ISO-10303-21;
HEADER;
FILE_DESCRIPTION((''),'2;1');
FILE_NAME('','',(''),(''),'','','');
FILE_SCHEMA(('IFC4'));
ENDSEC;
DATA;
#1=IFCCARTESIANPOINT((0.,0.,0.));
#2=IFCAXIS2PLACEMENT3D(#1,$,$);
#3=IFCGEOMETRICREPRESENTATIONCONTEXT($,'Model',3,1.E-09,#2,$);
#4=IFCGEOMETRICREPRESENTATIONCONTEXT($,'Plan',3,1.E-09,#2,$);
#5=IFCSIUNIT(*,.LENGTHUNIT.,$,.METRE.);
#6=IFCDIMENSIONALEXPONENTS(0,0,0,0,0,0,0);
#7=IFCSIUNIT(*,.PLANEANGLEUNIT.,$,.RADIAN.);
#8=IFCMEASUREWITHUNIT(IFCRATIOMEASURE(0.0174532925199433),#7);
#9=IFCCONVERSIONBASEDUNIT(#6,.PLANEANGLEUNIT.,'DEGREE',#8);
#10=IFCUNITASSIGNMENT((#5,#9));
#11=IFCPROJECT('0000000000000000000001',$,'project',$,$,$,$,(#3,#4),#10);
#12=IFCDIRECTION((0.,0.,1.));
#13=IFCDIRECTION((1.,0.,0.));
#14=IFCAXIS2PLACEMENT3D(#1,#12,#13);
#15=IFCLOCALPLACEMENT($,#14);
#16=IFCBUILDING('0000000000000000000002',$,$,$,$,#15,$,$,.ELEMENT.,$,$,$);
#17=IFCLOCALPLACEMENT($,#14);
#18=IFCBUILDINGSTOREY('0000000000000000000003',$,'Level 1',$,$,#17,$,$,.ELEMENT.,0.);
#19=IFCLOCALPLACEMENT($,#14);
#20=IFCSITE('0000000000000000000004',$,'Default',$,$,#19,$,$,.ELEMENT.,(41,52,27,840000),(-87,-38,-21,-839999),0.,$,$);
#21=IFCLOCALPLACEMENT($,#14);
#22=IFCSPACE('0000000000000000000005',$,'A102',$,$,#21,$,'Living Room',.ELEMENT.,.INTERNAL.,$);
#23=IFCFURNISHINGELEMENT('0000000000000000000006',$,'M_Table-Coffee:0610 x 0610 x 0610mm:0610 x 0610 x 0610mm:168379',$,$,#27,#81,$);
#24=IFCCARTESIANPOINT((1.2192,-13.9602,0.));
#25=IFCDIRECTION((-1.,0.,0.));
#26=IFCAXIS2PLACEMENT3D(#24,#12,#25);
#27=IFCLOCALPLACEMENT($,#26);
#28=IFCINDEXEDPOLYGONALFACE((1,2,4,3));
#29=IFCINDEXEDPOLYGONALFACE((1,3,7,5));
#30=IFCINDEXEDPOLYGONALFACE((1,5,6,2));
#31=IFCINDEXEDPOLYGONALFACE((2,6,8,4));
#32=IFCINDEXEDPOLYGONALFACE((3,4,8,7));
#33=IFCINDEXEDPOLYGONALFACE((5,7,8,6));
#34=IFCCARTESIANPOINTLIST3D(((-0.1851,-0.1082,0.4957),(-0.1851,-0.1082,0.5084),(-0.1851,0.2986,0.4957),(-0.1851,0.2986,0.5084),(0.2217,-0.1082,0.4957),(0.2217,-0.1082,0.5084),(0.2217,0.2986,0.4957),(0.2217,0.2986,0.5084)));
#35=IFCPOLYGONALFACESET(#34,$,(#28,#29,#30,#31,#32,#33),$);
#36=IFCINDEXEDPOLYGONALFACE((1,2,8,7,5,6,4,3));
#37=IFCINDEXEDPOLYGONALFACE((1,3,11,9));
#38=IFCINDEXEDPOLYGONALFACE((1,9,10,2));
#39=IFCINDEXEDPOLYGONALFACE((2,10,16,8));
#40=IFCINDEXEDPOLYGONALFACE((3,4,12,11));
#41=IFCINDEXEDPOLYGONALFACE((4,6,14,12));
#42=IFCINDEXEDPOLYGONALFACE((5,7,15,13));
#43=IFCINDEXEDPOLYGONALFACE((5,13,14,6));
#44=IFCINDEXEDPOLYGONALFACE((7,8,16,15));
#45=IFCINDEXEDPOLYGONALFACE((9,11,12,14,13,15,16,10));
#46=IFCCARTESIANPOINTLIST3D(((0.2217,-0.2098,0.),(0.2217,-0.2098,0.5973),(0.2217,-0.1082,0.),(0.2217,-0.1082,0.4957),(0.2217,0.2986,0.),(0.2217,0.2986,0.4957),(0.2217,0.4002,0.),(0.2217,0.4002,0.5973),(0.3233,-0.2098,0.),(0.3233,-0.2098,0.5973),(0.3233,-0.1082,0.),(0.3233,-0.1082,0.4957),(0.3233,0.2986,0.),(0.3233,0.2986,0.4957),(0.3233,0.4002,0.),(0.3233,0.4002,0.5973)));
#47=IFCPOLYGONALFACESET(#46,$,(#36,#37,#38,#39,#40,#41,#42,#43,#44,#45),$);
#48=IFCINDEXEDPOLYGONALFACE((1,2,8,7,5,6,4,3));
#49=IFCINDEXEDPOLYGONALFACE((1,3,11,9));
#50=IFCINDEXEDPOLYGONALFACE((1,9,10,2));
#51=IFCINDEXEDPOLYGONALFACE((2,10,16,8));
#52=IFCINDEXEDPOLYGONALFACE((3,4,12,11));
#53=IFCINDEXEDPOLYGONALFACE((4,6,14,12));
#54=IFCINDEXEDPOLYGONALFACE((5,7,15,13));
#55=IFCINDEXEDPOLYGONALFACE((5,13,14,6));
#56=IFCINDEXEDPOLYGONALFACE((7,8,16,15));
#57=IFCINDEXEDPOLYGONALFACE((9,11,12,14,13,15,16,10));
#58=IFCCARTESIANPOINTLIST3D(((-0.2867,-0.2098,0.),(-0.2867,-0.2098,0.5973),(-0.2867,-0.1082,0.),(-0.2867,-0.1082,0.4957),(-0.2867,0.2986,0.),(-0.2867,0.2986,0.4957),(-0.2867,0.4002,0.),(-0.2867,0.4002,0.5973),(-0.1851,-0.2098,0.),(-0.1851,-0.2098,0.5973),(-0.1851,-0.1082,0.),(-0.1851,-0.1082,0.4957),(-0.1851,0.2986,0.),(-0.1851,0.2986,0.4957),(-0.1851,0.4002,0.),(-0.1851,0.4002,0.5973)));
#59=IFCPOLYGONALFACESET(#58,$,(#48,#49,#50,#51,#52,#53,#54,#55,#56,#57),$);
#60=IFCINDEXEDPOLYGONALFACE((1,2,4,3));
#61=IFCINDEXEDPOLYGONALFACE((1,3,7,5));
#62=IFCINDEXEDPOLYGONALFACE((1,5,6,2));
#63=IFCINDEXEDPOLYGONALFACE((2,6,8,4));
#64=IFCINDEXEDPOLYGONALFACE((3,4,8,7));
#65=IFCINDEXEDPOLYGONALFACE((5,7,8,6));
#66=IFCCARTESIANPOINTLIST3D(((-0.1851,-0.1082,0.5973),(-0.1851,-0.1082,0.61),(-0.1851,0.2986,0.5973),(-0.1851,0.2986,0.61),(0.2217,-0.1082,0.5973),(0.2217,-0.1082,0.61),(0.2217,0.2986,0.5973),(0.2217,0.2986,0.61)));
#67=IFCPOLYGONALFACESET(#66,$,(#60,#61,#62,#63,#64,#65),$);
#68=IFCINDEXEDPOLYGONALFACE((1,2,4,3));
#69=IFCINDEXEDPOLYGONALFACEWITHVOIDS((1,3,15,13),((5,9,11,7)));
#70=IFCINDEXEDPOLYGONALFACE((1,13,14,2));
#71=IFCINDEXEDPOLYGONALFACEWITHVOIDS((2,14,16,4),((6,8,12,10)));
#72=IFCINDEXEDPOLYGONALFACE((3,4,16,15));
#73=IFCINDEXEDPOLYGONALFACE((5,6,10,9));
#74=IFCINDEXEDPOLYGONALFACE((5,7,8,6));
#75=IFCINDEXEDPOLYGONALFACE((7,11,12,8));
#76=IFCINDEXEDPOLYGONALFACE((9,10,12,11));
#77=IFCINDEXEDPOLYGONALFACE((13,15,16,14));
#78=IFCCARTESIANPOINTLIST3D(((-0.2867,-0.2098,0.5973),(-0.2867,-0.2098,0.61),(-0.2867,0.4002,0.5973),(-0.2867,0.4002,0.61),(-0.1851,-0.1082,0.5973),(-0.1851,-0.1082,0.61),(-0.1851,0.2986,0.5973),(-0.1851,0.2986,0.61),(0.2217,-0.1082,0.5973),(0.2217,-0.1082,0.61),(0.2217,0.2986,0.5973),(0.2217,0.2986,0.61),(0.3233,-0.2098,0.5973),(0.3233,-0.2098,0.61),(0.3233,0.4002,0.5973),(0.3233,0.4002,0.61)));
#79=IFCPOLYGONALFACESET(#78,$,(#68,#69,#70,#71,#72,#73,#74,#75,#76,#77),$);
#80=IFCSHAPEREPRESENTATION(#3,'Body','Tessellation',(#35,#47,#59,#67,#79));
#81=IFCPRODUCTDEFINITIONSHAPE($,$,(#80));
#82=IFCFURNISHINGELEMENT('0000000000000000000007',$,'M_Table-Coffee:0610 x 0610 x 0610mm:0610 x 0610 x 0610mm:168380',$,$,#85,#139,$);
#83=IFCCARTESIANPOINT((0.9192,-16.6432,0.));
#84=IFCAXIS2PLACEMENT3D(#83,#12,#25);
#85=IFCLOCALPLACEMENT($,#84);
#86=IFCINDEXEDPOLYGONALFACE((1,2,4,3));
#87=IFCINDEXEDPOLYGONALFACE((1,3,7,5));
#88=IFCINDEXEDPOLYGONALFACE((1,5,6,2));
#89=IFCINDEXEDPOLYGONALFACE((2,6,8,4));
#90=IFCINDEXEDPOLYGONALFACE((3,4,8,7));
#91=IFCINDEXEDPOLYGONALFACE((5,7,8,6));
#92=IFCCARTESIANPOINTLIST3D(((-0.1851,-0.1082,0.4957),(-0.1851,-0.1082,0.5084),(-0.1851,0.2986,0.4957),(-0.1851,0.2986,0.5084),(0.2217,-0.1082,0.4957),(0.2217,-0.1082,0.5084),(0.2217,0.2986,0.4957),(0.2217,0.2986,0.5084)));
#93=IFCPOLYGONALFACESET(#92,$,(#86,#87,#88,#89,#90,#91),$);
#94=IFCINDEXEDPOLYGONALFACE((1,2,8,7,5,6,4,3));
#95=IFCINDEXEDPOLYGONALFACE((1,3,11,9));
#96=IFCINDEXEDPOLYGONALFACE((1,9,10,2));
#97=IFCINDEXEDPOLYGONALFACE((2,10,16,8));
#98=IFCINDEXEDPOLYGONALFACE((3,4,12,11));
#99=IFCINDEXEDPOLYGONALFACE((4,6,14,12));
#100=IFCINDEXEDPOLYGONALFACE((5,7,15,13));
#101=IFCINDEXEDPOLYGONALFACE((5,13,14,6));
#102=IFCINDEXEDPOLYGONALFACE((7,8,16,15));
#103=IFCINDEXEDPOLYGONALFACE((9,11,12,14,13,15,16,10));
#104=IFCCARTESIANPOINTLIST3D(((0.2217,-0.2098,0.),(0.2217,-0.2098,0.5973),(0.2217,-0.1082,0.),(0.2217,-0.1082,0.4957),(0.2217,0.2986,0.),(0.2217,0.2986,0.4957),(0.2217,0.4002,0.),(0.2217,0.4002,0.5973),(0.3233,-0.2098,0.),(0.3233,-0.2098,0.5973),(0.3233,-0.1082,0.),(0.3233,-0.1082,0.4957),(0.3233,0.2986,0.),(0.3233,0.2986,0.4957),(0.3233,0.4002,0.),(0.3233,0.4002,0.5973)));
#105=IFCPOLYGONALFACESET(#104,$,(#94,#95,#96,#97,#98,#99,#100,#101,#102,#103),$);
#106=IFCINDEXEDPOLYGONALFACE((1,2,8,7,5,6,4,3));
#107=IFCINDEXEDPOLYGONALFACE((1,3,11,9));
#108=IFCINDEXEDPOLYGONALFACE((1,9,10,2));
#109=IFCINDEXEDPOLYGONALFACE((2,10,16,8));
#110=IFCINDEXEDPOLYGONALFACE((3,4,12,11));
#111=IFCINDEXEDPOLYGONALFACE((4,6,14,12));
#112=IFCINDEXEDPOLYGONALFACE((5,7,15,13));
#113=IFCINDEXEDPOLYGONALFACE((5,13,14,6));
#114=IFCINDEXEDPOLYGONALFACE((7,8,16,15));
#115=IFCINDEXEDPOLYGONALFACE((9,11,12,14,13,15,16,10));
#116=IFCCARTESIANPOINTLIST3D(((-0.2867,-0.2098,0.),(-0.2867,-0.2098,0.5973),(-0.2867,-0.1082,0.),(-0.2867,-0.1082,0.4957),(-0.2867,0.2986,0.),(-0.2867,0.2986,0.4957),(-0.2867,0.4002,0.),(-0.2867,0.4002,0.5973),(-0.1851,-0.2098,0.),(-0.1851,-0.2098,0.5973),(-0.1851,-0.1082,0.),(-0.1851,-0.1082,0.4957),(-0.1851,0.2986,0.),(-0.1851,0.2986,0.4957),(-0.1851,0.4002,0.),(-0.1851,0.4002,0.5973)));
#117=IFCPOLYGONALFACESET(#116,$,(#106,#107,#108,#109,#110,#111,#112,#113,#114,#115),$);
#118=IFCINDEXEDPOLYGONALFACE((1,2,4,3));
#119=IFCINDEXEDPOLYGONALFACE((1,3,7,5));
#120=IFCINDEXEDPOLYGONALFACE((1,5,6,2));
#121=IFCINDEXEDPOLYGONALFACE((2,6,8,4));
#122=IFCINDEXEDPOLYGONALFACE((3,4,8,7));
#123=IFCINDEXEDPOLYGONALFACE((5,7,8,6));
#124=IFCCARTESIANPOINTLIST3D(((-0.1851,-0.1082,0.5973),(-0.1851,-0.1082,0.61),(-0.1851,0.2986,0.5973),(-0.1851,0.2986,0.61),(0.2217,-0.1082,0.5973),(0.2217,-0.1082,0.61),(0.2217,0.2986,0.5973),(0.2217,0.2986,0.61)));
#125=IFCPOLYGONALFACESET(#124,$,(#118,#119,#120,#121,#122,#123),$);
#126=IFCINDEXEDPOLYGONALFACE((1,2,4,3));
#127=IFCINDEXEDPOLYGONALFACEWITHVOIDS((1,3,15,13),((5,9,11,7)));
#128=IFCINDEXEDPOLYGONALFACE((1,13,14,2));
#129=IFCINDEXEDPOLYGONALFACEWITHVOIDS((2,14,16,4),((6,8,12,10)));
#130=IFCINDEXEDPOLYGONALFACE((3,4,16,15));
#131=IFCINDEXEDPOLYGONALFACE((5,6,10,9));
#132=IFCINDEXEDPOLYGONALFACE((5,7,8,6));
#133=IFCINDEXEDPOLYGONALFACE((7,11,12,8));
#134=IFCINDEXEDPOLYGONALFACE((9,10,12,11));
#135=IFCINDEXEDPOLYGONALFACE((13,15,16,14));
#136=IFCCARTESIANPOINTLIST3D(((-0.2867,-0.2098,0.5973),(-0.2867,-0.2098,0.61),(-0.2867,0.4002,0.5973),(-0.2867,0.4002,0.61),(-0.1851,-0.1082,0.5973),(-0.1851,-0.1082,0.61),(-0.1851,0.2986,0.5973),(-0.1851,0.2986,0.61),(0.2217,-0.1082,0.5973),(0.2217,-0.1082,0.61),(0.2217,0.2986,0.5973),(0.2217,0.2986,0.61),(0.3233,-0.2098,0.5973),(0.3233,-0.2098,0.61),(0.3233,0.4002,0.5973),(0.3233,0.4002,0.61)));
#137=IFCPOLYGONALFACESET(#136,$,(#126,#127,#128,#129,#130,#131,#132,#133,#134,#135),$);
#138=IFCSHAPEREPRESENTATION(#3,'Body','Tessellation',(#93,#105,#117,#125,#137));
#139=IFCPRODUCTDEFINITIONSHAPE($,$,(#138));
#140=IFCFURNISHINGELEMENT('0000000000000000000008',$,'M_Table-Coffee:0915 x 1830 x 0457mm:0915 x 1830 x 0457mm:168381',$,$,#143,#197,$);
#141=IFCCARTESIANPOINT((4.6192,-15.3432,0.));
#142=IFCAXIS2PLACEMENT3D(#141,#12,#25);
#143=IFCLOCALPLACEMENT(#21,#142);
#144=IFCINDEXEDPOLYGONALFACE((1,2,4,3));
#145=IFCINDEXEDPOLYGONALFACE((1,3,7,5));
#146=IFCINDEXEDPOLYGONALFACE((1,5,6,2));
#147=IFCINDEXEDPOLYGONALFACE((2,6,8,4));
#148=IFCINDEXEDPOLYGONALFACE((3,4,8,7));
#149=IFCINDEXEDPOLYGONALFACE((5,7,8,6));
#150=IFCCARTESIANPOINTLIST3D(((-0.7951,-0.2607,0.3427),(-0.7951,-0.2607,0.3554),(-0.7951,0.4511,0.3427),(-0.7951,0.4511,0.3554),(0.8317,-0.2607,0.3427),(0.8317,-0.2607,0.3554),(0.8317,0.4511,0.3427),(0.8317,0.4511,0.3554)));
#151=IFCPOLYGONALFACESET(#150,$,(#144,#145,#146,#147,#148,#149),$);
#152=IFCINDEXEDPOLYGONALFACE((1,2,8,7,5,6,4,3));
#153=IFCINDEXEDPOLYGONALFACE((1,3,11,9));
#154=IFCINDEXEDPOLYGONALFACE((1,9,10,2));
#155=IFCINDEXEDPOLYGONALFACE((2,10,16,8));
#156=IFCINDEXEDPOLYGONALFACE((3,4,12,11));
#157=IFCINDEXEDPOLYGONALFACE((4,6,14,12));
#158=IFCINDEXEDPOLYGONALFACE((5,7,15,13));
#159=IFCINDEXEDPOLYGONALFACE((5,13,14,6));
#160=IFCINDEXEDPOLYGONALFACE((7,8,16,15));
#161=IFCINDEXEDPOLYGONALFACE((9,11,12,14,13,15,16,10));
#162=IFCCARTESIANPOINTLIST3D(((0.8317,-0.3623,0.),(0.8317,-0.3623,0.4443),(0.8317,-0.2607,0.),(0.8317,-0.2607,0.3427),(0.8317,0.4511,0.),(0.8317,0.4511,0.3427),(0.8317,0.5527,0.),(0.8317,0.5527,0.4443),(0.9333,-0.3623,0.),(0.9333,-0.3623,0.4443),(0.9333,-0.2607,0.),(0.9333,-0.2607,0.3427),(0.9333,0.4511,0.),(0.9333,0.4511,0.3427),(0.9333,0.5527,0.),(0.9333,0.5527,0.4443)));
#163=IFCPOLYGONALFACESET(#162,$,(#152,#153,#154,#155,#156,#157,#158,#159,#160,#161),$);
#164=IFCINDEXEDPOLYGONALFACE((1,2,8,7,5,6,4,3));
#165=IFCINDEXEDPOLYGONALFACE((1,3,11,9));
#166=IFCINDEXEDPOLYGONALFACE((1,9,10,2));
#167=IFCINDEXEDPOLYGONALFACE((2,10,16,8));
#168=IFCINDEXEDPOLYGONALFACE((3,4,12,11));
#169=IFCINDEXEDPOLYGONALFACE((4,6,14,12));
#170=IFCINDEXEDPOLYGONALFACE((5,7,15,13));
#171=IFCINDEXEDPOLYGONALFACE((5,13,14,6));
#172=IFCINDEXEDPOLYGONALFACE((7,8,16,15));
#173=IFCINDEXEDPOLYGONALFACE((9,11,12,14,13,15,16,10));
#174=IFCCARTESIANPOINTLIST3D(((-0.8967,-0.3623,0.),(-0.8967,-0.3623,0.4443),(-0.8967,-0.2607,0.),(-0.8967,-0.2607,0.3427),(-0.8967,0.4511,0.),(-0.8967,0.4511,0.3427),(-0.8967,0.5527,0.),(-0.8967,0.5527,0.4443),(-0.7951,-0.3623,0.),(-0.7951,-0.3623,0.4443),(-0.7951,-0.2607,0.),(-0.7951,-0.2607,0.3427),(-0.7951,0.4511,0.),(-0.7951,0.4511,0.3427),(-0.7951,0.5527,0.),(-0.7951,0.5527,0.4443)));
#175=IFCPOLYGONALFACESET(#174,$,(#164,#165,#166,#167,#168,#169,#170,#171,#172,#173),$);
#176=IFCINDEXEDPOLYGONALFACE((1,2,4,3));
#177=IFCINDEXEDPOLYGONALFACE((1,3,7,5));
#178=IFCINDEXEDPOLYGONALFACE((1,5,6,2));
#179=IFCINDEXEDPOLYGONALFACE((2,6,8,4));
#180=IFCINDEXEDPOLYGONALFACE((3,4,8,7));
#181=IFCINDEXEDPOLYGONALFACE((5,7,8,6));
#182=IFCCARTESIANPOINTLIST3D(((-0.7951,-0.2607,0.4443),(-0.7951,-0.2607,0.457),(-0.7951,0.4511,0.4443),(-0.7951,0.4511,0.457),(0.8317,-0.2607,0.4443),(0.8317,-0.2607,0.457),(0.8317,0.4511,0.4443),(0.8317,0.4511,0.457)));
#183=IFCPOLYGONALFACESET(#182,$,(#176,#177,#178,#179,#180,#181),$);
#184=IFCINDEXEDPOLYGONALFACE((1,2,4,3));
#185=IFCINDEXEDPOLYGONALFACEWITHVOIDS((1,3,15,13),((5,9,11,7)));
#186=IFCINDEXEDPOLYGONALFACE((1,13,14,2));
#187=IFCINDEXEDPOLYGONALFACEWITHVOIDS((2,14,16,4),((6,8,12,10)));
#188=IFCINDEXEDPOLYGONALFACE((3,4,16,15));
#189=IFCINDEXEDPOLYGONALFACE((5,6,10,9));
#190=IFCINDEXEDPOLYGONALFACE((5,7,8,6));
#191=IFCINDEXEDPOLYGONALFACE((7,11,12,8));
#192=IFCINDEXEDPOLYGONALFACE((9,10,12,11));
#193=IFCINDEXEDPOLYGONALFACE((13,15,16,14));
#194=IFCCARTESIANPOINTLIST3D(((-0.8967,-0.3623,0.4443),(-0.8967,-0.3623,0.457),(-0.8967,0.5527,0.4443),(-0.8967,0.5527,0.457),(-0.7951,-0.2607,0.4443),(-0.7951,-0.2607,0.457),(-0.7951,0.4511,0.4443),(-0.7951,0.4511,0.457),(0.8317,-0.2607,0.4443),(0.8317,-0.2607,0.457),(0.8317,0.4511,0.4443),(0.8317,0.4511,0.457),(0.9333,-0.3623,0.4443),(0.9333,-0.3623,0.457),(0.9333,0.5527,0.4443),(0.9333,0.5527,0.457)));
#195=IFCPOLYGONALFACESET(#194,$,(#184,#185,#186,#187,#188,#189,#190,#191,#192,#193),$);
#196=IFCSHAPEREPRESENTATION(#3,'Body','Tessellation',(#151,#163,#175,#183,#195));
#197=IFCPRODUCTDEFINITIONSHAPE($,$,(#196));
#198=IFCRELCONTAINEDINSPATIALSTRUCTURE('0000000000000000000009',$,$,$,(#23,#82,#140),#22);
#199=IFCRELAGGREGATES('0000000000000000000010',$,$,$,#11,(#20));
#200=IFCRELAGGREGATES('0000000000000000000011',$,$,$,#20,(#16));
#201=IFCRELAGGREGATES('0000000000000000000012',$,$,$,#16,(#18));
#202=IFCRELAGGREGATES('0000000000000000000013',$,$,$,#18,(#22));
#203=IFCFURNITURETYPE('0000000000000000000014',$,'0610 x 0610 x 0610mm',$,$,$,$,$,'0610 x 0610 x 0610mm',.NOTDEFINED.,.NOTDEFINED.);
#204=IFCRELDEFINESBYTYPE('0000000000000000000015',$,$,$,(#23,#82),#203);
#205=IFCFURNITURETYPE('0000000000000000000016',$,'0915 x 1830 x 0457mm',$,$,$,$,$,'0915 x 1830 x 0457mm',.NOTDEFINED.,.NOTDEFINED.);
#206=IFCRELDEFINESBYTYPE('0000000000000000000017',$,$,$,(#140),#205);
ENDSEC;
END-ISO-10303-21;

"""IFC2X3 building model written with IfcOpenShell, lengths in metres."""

from ifc_helpers import new_model, entity, si_unit, converted_unit, frame, origin, origin_with_axes, origin_2d_with_axis, place, context, project, spatial, polyline, rectangle, outline, extrude, source, transform, mapped, type_object, type_shapes, element, save


model = new_model("IFC2X3")

# Units and contexts
model_context = context("Model", 3, precision=1e-09, world=origin())
plan_context = context("Plan", 3, precision=1e-09, world=origin())
ifc_project = project(units=[si_unit("LENGTHUNIT", "METRE"), converted_unit("PLANEANGLEUNIT", "DEGREE", entity("IfcRatioMeasure", 0.0174532925199433), si_unit("PLANEANGLEUNIT", "RADIAN"), dimensions=[0, 0, 0, 0, 0, 0, 0])], contexts=[model_context, plan_context])

# Site, building, storey, space
site_placement = place(None, origin_with_axes())
site = spatial("IfcSite", under=ifc_project, at=site_placement, Name="Default", CompositionType="ELEMENT", RefLatitude=(41, 52, 27, 840000), RefLongitude=(-87, -38, -21, -839999), RefElevation=0.0)
building_placement = place(None, origin_with_axes())
building = spatial("IfcBuilding", under=site, at=building_placement, CompositionType="ELEMENT")
storey_placement = place(None, origin_with_axes())
storey = spatial("IfcBuildingStorey", under=building, at=storey_placement, Name="Level 1", CompositionType="ELEMENT", Elevation=0.0)
space_placement = place(None, origin_with_axes())
space = spatial("IfcSpace", under=storey, at=space_placement, Name="A102", LongName="Living Room", CompositionType="ELEMENT", InteriorOrExteriorSpace="INTERNAL")

# Furnishing elements
furniture_type_1 = type_object("IfcFurnitureType", Name="0610 x 0610 x 0610mm", ElementType="0610 x 0610 x 0610mm", AssemblyPlace="NOTDEFINED")
shared_shape_1 = source(origin(), model_context, "Body", "SweptSolid", [
    extrude(rectangle(XDim=0.4068, YDim=0.4068, at=origin_2d_with_axis()), frame((0.0183, 0.0952, 0.4957), z_axis=(0.0, 0.0, 1.0), x_axis=(-1.0, 0.0, 0.0)), (0.0, 0.0, 1.0), 0.0127),
    extrude(outline(polyline([(-0.2732, -0.305), (0.324, -0.305), (0.324, 0.305), (-0.2732, 0.305), (-0.2732, 0.2034), (0.2225, 0.2034), (0.2225, -0.2034), (-0.2732, -0.2034), (-0.2732, -0.305)])), frame((0.2217, 0.0952, 0.2732), z_axis=(1.0, 0.0, 0.0), x_axis=(0.0, 0.0, 1.0)), (0.0, 0.0, 1.0), 0.1016),
    extrude(outline(polyline([(-0.305, -0.3241), (0.305, -0.3241), (0.305, 0.2733), (0.2034, 0.2733), (0.2034, -0.2224), (-0.2034, -0.2224), (-0.2034, 0.2733), (-0.305, 0.2733), (-0.305, -0.3241)])), frame((-0.2867, 0.0952, 0.2733), z_axis=(1.0, 0.0, 0.0), x_axis=(0.0, -1.0, 0.0)), (0.0, 0.0, 1.0), 0.1016),
    extrude(rectangle(XDim=0.4068, YDim=0.4068, at=origin_2d_with_axis()), frame((0.0183, 0.0952, 0.5973), z_axis=(0.0, 0.0, 1.0), x_axis=(-1.0, 0.0, 0.0)), (0.0, 0.0, 1.0), 0.0127),
    extrude(outline(polyline([(-0.305, -0.305), (0.305, -0.305), (0.305, 0.305), (-0.305, 0.305), (-0.305, -0.305)]), holes=[polyline([(-0.2034, -0.2034), (-0.2034, 0.2034), (0.2034, 0.2034), (0.2034, -0.2034), (-0.2034, -0.2034)])]), frame((0.0183, 0.0952, 0.5973), z_axis=(0.0, 0.0, 1.0), x_axis=(-1.0, 0.0, 0.0)), (0.0, 0.0, 1.0), 0.0127),
])
type_shapes(furniture_type_1, [shared_shape_1])
for number, where, z_axis, x_axis, name in (
    (1, (1.2192, -13.9602, 0.0), (0.0, 0.0, 1.0), (-1.0, 0.0, 0.0), "M_Table-Coffee:0610 x 0610 x 0610mm:0610 x 0610 x 0610mm:168379"),
    (2, (0.9192, -16.6432, 0.0), (0.0, 0.0, 1.0), (-1.0, 0.0, 0.0), "M_Table-Coffee:0610 x 0610 x 0610mm:0610 x 0610 x 0610mm:168380"),
):
    element("IfcFurnishingElement", number, at=place(None, frame(where, z_axis=z_axis, x_axis=x_axis)), inside=space, type_object=furniture_type_1, Name=name, context=model_context, shape_type="MappedRepresentation", body=[
        mapped(shared_shape_1, transform((0.0, 0.0, 0.0), scale=1.0)),
    ])
furniture_type_2 = type_object("IfcFurnitureType", Name="0915 x 1830 x 0457mm", ElementType="0915 x 1830 x 0457mm", AssemblyPlace="NOTDEFINED")
shared_shape_2 = source(origin(), model_context, "Body", "SweptSolid", [
    extrude(rectangle(XDim=1.6268, YDim=0.7118, at=origin_2d_with_axis()), frame((0.0183, 0.0952, 0.3427), z_axis=(0.0, 0.0, 1.0), x_axis=(-1.0, 0.0, 0.0)), (0.0, 0.0, 1.0), 0.0127),
    extrude(outline(polyline([(-0.1967, -0.4575), (0.2475, -0.4575), (0.2475, 0.4575), (-0.1967, 0.4575), (-0.1967, 0.3559), (0.146, 0.3559), (0.146, -0.3559), (-0.1967, -0.3559), (-0.1967, -0.4575)])), frame((0.8317, 0.0952, 0.1967), z_axis=(1.0, 0.0, 0.0), x_axis=(0.0, 0.0, 1.0)), (0.0, 0.0, 1.0), 0.1016),
    extrude(outline(polyline([(-0.4575, -0.2476), (0.4575, -0.2476), (0.4575, 0.1968), (0.3559, 0.1968), (0.3559, -0.1459), (-0.3559, -0.1459), (-0.3559, 0.1968), (-0.4575, 0.1968), (-0.4575, -0.2476)])), frame((-0.8967, 0.0952, 0.1968), z_axis=(1.0, 0.0, 0.0), x_axis=(0.0, -1.0, 0.0)), (0.0, 0.0, 1.0), 0.1016),
    extrude(rectangle(XDim=1.6268, YDim=0.7118, at=origin_2d_with_axis()), frame((0.0183, 0.0952, 0.4443), z_axis=(0.0, 0.0, 1.0), x_axis=(-1.0, 0.0, 0.0)), (0.0, 0.0, 1.0), 0.0127),
    extrude(outline(polyline([(-0.915, -0.4575), (0.915, -0.4575), (0.915, 0.4575), (-0.915, 0.4575), (-0.915, -0.4575)]), holes=[polyline([(-0.8134, -0.3559), (-0.8134, 0.3559), (0.8134, 0.3559), (0.8134, -0.3559), (-0.8134, -0.3559)])]), frame((0.0183, 0.0952, 0.4443), z_axis=(0.0, 0.0, 1.0), x_axis=(-1.0, 0.0, 0.0)), (0.0, 0.0, 1.0), 0.0127),
])
type_shapes(furniture_type_2, [shared_shape_2])
furnishing_placement = place(space_placement, frame((4.6192, -15.3432, 0.0), z_axis=(0.0, 0.0, 1.0), x_axis=(-1.0, 0.0, 0.0)))
element("IfcFurnishingElement", 3, at=furnishing_placement, inside=space, type_object=furniture_type_2, Name="M_Table-Coffee:0915 x 1830 x 0457mm:0915 x 1830 x 0457mm:168381", context=model_context, shape_type="MappedRepresentation", body=[
    mapped(shared_shape_2, transform((0.0, 0.0, 0.0), scale=1.0)),
])

save(model, "model.ifc")
